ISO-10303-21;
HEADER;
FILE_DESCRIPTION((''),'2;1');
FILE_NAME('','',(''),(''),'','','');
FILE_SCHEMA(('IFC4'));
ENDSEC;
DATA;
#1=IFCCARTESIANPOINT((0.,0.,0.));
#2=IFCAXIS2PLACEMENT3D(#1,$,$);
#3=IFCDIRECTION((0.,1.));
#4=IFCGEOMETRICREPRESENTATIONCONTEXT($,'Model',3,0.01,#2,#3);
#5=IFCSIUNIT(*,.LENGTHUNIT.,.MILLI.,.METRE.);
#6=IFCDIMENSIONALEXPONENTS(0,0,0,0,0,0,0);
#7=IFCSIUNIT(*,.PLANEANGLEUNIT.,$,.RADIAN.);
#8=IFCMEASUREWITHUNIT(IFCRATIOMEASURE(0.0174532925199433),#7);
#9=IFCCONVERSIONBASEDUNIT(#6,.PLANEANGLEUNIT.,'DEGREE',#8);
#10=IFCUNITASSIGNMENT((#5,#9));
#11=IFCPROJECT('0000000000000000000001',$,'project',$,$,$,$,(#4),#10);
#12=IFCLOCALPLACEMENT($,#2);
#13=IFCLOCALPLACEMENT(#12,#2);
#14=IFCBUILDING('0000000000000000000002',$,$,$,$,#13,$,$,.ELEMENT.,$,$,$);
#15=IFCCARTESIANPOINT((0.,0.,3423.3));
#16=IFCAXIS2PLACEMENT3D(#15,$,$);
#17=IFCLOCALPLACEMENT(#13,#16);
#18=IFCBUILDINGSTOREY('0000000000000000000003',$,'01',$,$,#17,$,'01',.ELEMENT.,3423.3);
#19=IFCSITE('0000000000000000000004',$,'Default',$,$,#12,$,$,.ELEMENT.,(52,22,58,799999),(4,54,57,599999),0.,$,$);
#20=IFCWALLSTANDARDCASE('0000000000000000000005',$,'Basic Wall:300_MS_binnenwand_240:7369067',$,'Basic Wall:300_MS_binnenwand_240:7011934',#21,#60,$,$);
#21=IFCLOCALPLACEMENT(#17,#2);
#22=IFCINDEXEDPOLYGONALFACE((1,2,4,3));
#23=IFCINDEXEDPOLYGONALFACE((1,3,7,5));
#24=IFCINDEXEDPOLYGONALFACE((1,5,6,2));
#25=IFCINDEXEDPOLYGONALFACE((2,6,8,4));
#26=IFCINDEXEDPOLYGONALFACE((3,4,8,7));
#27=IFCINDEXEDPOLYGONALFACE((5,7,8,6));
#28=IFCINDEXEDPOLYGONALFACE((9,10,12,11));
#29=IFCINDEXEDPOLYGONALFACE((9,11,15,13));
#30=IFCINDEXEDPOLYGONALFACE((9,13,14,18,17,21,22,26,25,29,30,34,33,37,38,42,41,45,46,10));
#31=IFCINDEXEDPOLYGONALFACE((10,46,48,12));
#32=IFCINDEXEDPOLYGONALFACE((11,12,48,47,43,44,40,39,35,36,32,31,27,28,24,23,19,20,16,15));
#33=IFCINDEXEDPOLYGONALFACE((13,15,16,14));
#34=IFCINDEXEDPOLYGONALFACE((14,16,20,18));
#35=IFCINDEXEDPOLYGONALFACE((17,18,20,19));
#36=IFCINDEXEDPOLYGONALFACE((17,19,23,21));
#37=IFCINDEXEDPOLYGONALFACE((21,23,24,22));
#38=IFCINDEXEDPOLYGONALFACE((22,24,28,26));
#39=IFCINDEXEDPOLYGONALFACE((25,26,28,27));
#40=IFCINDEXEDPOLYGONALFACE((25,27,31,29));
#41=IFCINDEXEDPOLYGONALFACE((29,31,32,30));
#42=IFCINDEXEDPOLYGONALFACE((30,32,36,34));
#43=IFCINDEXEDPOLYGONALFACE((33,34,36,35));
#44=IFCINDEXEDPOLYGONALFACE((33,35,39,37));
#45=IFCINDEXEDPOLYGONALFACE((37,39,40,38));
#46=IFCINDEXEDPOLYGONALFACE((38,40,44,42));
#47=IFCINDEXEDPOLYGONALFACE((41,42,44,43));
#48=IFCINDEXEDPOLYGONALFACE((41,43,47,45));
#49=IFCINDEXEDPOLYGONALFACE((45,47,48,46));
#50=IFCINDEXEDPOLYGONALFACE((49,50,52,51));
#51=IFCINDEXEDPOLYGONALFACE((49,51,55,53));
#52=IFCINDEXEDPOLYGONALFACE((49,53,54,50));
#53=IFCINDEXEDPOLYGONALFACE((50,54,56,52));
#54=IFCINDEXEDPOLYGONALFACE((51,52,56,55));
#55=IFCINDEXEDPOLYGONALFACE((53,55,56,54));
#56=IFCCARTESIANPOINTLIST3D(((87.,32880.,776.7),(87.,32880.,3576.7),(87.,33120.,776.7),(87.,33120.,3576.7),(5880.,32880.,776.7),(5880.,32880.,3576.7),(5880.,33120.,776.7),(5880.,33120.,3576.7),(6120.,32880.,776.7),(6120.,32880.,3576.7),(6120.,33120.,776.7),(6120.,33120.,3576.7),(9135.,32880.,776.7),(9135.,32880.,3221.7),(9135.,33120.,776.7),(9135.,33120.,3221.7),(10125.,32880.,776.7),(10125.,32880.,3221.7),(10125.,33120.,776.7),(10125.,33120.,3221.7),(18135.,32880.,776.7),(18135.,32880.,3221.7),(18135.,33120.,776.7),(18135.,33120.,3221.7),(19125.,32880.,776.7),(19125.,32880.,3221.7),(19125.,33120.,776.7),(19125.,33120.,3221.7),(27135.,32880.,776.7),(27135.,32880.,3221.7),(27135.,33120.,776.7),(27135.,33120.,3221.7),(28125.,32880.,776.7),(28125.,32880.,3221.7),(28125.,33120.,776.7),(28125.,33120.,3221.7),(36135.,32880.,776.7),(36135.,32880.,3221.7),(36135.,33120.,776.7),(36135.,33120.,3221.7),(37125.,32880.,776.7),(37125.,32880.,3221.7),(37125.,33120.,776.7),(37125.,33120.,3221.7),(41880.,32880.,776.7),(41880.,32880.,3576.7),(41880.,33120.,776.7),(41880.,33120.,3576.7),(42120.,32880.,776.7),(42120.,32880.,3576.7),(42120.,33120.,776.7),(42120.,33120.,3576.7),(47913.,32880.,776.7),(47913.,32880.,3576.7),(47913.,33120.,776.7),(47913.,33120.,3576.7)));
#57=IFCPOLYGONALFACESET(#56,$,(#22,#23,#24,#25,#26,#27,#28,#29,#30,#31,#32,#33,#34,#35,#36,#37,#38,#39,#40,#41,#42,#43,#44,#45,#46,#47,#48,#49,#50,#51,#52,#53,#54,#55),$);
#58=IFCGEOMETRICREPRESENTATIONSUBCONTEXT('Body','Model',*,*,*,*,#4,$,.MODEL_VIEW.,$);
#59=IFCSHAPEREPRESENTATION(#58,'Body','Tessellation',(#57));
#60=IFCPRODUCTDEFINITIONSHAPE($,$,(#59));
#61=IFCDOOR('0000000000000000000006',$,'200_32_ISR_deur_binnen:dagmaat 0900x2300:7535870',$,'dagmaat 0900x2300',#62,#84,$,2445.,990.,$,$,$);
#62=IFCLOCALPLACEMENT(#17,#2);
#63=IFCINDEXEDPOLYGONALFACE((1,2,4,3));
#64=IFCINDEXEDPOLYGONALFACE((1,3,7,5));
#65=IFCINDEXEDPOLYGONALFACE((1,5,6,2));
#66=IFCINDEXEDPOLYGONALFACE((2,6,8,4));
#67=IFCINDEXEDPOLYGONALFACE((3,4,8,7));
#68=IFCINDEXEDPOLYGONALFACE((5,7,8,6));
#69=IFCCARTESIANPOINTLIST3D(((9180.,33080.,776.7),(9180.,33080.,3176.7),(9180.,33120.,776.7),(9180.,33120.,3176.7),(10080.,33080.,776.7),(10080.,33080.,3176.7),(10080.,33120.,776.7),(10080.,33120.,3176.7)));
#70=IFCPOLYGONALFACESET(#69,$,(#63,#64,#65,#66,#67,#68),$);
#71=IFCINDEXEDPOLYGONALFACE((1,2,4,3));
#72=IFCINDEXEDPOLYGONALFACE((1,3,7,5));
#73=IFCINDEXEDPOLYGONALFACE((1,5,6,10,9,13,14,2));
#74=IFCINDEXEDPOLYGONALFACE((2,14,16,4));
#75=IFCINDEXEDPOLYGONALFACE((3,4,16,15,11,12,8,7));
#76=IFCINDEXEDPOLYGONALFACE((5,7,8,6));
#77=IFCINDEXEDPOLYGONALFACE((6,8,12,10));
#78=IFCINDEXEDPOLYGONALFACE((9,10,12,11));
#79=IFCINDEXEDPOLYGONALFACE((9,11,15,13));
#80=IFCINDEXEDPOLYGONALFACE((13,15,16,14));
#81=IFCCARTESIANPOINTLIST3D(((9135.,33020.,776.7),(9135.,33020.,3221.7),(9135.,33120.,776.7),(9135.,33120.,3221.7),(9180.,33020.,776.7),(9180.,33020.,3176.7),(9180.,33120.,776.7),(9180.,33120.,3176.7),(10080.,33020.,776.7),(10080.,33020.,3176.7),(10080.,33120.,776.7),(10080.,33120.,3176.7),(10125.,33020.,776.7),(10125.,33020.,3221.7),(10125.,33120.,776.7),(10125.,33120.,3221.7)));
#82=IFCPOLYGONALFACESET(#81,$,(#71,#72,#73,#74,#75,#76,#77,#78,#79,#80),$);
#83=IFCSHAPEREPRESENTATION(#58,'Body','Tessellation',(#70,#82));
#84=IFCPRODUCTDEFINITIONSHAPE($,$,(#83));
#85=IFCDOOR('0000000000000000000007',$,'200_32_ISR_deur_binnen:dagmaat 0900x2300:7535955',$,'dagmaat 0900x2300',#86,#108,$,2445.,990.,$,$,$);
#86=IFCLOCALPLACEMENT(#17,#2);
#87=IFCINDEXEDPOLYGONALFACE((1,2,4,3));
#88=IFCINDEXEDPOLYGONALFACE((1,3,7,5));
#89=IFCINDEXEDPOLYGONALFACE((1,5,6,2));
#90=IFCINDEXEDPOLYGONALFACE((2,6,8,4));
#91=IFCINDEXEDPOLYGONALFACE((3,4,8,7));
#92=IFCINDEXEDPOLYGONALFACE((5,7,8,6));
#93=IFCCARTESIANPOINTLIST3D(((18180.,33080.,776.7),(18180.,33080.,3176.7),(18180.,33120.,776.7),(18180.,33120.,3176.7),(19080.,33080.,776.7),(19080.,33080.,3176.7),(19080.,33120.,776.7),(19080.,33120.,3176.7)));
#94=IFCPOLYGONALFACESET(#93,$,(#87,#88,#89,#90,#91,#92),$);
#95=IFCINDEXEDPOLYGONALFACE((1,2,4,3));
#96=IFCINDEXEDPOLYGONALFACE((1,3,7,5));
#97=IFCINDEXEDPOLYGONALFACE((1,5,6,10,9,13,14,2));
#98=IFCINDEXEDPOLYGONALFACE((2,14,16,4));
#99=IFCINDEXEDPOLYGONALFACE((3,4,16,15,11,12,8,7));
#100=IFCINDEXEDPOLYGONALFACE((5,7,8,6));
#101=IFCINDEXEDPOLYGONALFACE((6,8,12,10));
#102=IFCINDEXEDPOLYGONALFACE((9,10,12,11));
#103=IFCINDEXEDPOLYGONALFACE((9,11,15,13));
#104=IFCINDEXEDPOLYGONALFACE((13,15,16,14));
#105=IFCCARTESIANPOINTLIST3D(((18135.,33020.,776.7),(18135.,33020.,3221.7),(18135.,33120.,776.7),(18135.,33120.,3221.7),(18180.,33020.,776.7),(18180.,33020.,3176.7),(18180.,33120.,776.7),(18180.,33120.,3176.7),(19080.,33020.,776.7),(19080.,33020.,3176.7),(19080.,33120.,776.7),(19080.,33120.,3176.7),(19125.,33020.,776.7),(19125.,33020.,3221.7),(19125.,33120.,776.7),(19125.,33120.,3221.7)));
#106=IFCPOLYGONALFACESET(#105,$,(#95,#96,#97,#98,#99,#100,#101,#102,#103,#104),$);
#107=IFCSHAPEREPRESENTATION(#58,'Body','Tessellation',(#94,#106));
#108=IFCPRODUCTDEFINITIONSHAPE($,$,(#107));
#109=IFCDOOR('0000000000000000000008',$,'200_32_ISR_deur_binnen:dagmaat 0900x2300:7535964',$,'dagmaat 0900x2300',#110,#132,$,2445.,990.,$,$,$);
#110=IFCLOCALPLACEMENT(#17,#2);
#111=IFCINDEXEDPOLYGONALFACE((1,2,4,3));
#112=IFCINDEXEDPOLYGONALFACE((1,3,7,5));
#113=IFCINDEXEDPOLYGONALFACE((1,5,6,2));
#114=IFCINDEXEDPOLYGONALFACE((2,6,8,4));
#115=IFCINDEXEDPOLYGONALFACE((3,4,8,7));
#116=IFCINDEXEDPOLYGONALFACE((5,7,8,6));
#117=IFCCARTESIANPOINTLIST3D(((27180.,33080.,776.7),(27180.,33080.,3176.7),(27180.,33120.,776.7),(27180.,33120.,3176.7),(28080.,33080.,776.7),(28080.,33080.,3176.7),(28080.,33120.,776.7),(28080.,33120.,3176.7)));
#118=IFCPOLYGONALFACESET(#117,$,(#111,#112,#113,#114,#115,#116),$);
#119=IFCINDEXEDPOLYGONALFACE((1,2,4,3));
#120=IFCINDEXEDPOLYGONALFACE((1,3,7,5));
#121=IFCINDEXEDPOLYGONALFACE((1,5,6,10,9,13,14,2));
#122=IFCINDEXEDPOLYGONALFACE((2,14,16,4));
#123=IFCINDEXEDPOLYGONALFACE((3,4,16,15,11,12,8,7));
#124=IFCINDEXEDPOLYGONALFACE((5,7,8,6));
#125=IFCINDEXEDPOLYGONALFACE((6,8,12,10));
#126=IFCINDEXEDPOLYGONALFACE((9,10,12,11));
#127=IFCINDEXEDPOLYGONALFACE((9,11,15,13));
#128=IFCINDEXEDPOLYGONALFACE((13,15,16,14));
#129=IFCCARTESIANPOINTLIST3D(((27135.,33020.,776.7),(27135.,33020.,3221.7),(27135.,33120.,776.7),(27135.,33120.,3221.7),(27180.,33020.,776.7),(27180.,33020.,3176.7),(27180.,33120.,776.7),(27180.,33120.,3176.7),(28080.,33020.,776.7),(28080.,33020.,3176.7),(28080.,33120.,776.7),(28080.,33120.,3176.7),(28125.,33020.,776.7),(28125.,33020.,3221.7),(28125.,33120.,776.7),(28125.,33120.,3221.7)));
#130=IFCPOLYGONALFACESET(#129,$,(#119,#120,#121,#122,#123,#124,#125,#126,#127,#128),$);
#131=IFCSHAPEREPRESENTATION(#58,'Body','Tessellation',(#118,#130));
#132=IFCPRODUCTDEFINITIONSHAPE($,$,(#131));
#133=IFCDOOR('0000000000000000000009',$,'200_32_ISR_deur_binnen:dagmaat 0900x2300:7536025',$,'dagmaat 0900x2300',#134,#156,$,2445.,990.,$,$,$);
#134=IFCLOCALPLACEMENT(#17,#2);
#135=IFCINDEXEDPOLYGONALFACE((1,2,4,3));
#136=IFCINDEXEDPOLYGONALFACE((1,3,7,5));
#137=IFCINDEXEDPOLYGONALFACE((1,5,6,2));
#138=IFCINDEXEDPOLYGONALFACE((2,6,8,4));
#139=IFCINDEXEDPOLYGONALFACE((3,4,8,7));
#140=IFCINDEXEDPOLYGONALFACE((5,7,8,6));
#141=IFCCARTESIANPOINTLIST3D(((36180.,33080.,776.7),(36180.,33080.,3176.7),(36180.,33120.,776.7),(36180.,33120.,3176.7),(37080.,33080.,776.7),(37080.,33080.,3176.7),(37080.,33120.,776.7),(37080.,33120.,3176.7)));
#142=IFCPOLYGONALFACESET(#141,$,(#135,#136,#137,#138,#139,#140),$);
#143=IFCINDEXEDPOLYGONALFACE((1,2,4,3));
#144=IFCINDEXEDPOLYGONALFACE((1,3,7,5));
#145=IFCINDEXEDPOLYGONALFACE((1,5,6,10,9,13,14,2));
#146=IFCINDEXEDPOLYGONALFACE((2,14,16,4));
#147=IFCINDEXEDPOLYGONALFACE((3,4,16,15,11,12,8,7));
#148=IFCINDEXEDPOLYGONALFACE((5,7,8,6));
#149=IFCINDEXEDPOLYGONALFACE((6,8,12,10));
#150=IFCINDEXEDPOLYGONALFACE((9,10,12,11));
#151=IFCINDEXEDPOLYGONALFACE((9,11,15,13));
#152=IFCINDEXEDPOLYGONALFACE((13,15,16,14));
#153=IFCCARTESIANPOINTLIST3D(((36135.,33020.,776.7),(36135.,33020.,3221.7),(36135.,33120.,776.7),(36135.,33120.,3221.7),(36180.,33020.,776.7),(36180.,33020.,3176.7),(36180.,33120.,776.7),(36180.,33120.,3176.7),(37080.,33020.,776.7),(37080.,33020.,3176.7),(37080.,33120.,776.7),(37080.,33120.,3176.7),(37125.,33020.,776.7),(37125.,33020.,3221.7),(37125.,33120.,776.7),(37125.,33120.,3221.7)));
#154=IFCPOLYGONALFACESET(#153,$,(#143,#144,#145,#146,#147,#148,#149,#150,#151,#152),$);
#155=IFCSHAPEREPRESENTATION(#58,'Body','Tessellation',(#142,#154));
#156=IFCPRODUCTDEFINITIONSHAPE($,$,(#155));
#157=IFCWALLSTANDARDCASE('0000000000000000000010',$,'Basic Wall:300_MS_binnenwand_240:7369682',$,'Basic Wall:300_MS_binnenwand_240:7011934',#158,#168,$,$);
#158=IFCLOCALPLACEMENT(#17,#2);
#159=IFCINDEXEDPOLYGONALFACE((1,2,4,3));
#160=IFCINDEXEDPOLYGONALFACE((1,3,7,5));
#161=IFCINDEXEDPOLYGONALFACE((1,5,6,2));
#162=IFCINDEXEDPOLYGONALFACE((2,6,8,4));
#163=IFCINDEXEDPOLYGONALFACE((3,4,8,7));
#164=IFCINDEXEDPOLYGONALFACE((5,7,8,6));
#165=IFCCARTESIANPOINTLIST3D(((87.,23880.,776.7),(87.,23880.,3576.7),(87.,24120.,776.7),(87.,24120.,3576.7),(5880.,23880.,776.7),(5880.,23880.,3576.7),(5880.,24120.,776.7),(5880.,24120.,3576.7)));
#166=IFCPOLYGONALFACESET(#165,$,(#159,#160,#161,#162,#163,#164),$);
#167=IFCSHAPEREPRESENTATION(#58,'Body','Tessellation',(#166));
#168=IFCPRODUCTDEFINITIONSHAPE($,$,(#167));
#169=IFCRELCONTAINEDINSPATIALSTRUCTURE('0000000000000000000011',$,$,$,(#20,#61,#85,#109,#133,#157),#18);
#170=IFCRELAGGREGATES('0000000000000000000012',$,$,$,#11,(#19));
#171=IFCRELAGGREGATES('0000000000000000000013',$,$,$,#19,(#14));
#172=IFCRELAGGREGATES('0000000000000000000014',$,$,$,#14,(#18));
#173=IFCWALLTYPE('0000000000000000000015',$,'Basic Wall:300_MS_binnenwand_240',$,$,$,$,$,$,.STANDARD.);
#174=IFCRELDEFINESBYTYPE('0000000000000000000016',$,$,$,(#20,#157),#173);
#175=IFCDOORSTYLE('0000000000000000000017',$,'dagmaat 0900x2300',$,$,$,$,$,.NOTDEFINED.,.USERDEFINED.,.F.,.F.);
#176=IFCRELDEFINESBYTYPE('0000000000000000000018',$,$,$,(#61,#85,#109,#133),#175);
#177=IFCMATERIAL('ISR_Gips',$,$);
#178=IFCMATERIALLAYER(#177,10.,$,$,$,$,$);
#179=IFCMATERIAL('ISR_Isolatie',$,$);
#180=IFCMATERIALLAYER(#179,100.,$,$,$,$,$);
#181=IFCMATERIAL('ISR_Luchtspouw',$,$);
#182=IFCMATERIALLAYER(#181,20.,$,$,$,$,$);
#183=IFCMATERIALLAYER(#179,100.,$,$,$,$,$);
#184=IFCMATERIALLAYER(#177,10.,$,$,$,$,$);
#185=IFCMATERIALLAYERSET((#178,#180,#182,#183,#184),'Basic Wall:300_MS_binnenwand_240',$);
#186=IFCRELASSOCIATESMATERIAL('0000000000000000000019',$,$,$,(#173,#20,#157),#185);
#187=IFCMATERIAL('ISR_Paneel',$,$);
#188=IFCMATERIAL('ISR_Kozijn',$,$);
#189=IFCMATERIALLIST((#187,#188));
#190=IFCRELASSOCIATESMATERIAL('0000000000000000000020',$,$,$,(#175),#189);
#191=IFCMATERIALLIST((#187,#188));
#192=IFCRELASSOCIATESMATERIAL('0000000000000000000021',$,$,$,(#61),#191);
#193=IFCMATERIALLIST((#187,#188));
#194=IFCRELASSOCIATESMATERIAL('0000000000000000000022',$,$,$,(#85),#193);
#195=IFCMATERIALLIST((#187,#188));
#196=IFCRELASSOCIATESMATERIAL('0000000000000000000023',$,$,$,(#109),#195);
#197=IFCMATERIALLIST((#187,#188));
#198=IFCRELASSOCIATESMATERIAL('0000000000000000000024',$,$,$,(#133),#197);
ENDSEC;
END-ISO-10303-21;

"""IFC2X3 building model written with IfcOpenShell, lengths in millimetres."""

from ifc_helpers import new_model, entity, si_unit, converted_unit, direction, frame, frame_2d, origin, origin_2d_with_axis, place, context, subcontext, project, spatial, polyline, rectangle, outline, extrude, source, transform, mapped, material, material_list, layer, layer_set, layer_usage, type_object, type_shapes, element, fill, save


model = new_model("IFC2X3")

# Units and contexts
model_context = context("Model", 3, precision=0.01, world=origin(), true_north=direction((0.0, 1.0)))
body_context = subcontext(model_context, "Body", "Model", "MODEL_VIEW")
ifc_project = project(units=[si_unit("LENGTHUNIT", "METRE", prefix="MILLI"), converted_unit("PLANEANGLEUNIT", "DEGREE", entity("IfcRatioMeasure", 0.0174532925199433), si_unit("PLANEANGLEUNIT", "RADIAN"), dimensions=[0, 0, 0, 0, 0, 0, 0])], contexts=[model_context])

# Site, building, storey
site_placement = place(None, origin())
site = spatial("IfcSite", under=ifc_project, at=site_placement, Name="Default", CompositionType="ELEMENT", RefLatitude=(52, 22, 58, 799999), RefLongitude=(4, 54, 57, 599999), RefElevation=0.0)
building_placement = place(site_placement, origin())
building = spatial("IfcBuilding", under=site, at=building_placement, CompositionType="ELEMENT")
storey_placement = place(building_placement, frame((0.0, 0.0, 3423.3)))
storey = spatial("IfcBuildingStorey", under=building, at=storey_placement, Name="01", LongName="01", CompositionType="ELEMENT", Elevation=3423.3)

# Wall, openings, doors
ifc_material_1 = material(Name="ISR_Gips")
ifc_layer_1 = layer(ifc_material_1, 10.0)
ifc_material_2 = material(Name="ISR_Isolatie")
ifc_layer_2 = layer(ifc_material_2, 100.0)
ifc_material_3 = material(Name="ISR_Luchtspouw")
ifc_layer_3 = layer(ifc_material_3, 20.0)
ifc_layer_4 = layer(ifc_material_2, 100.0)
ifc_layer_5 = layer(ifc_material_1, 10.0)
ifc_layer_set_1 = layer_set([ifc_layer_1, ifc_layer_2, ifc_layer_3, ifc_layer_4, ifc_layer_5], Name="Basic Wall:300_MS_binnenwand_240")
ifc_layer_usage_1 = layer_usage(ifc_layer_set_1, "AXIS2", "NEGATIVE", 120.0)
wall_type_1 = type_object("IfcWallType", Name="Basic Wall:300_MS_binnenwand_240", PredefinedType="STANDARD", material=ifc_layer_set_1)
wall_1_placement = place(storey_placement, frame((87.0, 33000.0, 776.7)))
wall_1 = element("IfcWallStandardCase", 1, at=wall_1_placement, inside=storey, type_object=wall_type_1, material=ifc_layer_usage_1, Name="Basic Wall:300_MS_binnenwand_240:7369067", ObjectType="Basic Wall:300_MS_binnenwand_240:7011934", context=body_context, shape_type="SweptSolid", body=[
    extrude(rectangle(XDim=47826.0, YDim=240.0, at=frame_2d((23913.0, 0.0), x_axis=(-1.0, 0.0))), origin(), (0.0, 0.0, 1.0), 2800.0),
])
opening_1_placement = place(storey_placement, frame((87.0, 33000.0, 776.7)))
element("IfcOpeningElement", 2, at=opening_1_placement, cuts=wall_1, ObjectType="Opening", context=body_context, shape_type="SweptSolid", body=[
    extrude(rectangle(XDim=2800.0, YDim=240.0, at=frame_2d((0.0, 0.0), x_axis=(1.0, 0.0))), frame((5793.0, 0.0, 1400.0), z_axis=(1.0, 0.0, 0.0), x_axis=(0.0, 0.0, -1.0)), (0.0, 0.0, 1.0), 240.0),
])
opening_2_placement = place(storey_placement, frame((87.0, 33000.0, 776.7)))
element("IfcOpeningElement", 3, at=opening_2_placement, cuts=wall_1, ObjectType="Opening", context=body_context, shape_type="SweptSolid", body=[
    extrude(rectangle(XDim=2800.0, YDim=240.0, at=frame_2d((0.0, 0.0), x_axis=(1.0, 0.0))), frame((41793.0, 0.0, 1400.0), z_axis=(1.0, 0.0, 0.0), x_axis=(0.0, 0.0, -1.0)), (0.0, 0.0, 1.0), 240.0),
])
opening_3_placement = place(wall_1_placement, frame((9048.0, -120.0, 0.0)))
opening_3 = element("IfcOpeningElement", 4, at=opening_3_placement, cuts=wall_1, ObjectType="Opening", context=body_context, shape_type="SweptSolid", body=[
    extrude(rectangle(XDim=2445.0, YDim=990.0, at=frame_2d((1222.5, 495.0), x_axis=(-1.0, 0.0))), frame((0.0, 0.0, 0.0), z_axis=(0.0, 1.0, 0.0), x_axis=(0.0, 0.0, 1.0)), (0.0, 0.0, 1.0), 240.0),
])
opening_4_placement = place(wall_1_placement, frame((18048.0, -120.0, 0.0)))
opening_4 = element("IfcOpeningElement", 5, at=opening_4_placement, cuts=wall_1, ObjectType="Opening", context=body_context, shape_type="SweptSolid", body=[
    extrude(rectangle(XDim=2445.0, YDim=990.0, at=frame_2d((1222.5, 495.0), x_axis=(-1.0, 0.0))), frame((0.0, 0.0, 0.0), z_axis=(0.0, 1.0, 0.0), x_axis=(0.0, 0.0, 1.0)), (0.0, 0.0, 1.0), 240.0),
])
opening_5_placement = place(wall_1_placement, frame((27048.0, -120.0, 0.0)))
opening_5 = element("IfcOpeningElement", 6, at=opening_5_placement, cuts=wall_1, ObjectType="Opening", context=body_context, shape_type="SweptSolid", body=[
    extrude(rectangle(XDim=2445.0, YDim=990.0, at=frame_2d((1222.5, 495.0), x_axis=(-1.0, 0.0))), frame((0.0, 0.0, 0.0), z_axis=(0.0, 1.0, 0.0), x_axis=(0.0, 0.0, 1.0)), (0.0, 0.0, 1.0), 240.0),
])
opening_6_placement = place(wall_1_placement, frame((36048.0, -120.0, 0.0)))
opening_6 = element("IfcOpeningElement", 7, at=opening_6_placement, cuts=wall_1, ObjectType="Opening", context=body_context, shape_type="SweptSolid", body=[
    extrude(rectangle(XDim=2445.0, YDim=990.0, at=frame_2d((1222.5, 495.0), x_axis=(-1.0, 0.0))), frame((0.0, 0.0, 0.0), z_axis=(0.0, 1.0, 0.0), x_axis=(0.0, 0.0, 1.0)), (0.0, 0.0, 1.0), 240.0),
])
ifc_material_4 = material(Name="ISR_Paneel")
ifc_material_5 = material(Name="ISR_Kozijn")
ifc_material_list_1 = material_list([ifc_material_4, ifc_material_5])
ifc_material_list_2 = material_list([ifc_material_4, ifc_material_5])
door_style_1 = type_object("IfcDoorStyle", Name="dagmaat 0900x2300", ConstructionType="USERDEFINED", OperationType="NOTDEFINED", ParameterTakesPrecedence=False, Sizeable=False, material=ifc_material_list_2)
shared_shape_1 = source(origin(), body_context, "Body", "SweptSolid", [
    extrude(rectangle(XDim=900.0, YDim=40.0, at=origin_2d_with_axis()), frame((495.0, 220.0, 0.0)), (0.0, 0.0, 1.0), 2400.0),
    extrude(outline(polyline([(-1211.2, -450.0), (-1211.2, -495.0), (1233.7, -495.0), (1233.7, 495.0), (-1211.2, 495.0), (-1211.2, 450.0), (1188.8, 450.0), (1188.8, -450.0), (-1211.2, -450.0)])), frame((495.0, 140.0, 1211.2), z_axis=(0.0, -1.0, 0.0), x_axis=(0.0, 0.0, 1.0)), (0.0, 0.0, -1.0), 100.0),
])
type_shapes(door_style_1, [shared_shape_1])
door_1_placement = place(opening_3_placement, origin())
door_1 = element("IfcDoor", 8, at=door_1_placement, inside=storey, type_object=door_style_1, material=ifc_material_list_1, Name="200_32_ISR_deur_binnen:dagmaat 0900x2300:7535870", ObjectType="dagmaat 0900x2300", OverallHeight=2445.0, OverallWidth=990.0, context=body_context, shape_type="MappedRepresentation", body=[
    mapped(shared_shape_1, transform((0.0, 0.0, 0.0), scale=1.0)),
])
fill(opening_3, door_1)
ifc_material_list_3 = material_list([ifc_material_4, ifc_material_5])
door_2_placement = place(opening_4_placement, origin())
door_2 = element("IfcDoor", 9, at=door_2_placement, inside=storey, type_object=door_style_1, material=ifc_material_list_3, Name="200_32_ISR_deur_binnen:dagmaat 0900x2300:7535955", ObjectType="dagmaat 0900x2300", OverallHeight=2445.0, OverallWidth=990.0, context=body_context, shape_type="MappedRepresentation", body=[
    mapped(shared_shape_1, transform((0.0, 0.0, 0.0), scale=1.0)),
])
fill(opening_4, door_2)
ifc_material_list_4 = material_list([ifc_material_4, ifc_material_5])
door_3_placement = place(opening_5_placement, origin())
door_3 = element("IfcDoor", 10, at=door_3_placement, inside=storey, type_object=door_style_1, material=ifc_material_list_4, Name="200_32_ISR_deur_binnen:dagmaat 0900x2300:7535964", ObjectType="dagmaat 0900x2300", OverallHeight=2445.0, OverallWidth=990.0, context=body_context, shape_type="MappedRepresentation", body=[
    mapped(shared_shape_1, transform((0.0, 0.0, 0.0), scale=1.0)),
])
fill(opening_5, door_3)
ifc_material_list_5 = material_list([ifc_material_4, ifc_material_5])
door_4_placement = place(opening_6_placement, origin())
door_4 = element("IfcDoor", 11, at=door_4_placement, inside=storey, type_object=door_style_1, material=ifc_material_list_5, Name="200_32_ISR_deur_binnen:dagmaat 0900x2300:7536025", ObjectType="dagmaat 0900x2300", OverallHeight=2445.0, OverallWidth=990.0, context=body_context, shape_type="MappedRepresentation", body=[
    mapped(shared_shape_1, transform((0.0, 0.0, 0.0), scale=1.0)),
])
fill(opening_6, door_4)

# Wall
ifc_layer_usage_2 = layer_usage(ifc_layer_set_1, "AXIS2", "NEGATIVE", 120.0)
wall_2_placement = place(storey_placement, frame((87.0, 24000.0, 776.7)))
element("IfcWallStandardCase", 12, at=wall_2_placement, inside=storey, type_object=wall_type_1, material=ifc_layer_usage_2, Name="Basic Wall:300_MS_binnenwand_240:7369682", ObjectType="Basic Wall:300_MS_binnenwand_240:7011934", context=body_context, shape_type="SweptSolid", body=[
    extrude(rectangle(XDim=5793.0, YDim=240.0, at=frame_2d((2896.5, 0.0), x_axis=(-1.0, 0.0))), origin(), (0.0, 0.0, 1.0), 2800.0),
])

save(model, "model.ifc")
